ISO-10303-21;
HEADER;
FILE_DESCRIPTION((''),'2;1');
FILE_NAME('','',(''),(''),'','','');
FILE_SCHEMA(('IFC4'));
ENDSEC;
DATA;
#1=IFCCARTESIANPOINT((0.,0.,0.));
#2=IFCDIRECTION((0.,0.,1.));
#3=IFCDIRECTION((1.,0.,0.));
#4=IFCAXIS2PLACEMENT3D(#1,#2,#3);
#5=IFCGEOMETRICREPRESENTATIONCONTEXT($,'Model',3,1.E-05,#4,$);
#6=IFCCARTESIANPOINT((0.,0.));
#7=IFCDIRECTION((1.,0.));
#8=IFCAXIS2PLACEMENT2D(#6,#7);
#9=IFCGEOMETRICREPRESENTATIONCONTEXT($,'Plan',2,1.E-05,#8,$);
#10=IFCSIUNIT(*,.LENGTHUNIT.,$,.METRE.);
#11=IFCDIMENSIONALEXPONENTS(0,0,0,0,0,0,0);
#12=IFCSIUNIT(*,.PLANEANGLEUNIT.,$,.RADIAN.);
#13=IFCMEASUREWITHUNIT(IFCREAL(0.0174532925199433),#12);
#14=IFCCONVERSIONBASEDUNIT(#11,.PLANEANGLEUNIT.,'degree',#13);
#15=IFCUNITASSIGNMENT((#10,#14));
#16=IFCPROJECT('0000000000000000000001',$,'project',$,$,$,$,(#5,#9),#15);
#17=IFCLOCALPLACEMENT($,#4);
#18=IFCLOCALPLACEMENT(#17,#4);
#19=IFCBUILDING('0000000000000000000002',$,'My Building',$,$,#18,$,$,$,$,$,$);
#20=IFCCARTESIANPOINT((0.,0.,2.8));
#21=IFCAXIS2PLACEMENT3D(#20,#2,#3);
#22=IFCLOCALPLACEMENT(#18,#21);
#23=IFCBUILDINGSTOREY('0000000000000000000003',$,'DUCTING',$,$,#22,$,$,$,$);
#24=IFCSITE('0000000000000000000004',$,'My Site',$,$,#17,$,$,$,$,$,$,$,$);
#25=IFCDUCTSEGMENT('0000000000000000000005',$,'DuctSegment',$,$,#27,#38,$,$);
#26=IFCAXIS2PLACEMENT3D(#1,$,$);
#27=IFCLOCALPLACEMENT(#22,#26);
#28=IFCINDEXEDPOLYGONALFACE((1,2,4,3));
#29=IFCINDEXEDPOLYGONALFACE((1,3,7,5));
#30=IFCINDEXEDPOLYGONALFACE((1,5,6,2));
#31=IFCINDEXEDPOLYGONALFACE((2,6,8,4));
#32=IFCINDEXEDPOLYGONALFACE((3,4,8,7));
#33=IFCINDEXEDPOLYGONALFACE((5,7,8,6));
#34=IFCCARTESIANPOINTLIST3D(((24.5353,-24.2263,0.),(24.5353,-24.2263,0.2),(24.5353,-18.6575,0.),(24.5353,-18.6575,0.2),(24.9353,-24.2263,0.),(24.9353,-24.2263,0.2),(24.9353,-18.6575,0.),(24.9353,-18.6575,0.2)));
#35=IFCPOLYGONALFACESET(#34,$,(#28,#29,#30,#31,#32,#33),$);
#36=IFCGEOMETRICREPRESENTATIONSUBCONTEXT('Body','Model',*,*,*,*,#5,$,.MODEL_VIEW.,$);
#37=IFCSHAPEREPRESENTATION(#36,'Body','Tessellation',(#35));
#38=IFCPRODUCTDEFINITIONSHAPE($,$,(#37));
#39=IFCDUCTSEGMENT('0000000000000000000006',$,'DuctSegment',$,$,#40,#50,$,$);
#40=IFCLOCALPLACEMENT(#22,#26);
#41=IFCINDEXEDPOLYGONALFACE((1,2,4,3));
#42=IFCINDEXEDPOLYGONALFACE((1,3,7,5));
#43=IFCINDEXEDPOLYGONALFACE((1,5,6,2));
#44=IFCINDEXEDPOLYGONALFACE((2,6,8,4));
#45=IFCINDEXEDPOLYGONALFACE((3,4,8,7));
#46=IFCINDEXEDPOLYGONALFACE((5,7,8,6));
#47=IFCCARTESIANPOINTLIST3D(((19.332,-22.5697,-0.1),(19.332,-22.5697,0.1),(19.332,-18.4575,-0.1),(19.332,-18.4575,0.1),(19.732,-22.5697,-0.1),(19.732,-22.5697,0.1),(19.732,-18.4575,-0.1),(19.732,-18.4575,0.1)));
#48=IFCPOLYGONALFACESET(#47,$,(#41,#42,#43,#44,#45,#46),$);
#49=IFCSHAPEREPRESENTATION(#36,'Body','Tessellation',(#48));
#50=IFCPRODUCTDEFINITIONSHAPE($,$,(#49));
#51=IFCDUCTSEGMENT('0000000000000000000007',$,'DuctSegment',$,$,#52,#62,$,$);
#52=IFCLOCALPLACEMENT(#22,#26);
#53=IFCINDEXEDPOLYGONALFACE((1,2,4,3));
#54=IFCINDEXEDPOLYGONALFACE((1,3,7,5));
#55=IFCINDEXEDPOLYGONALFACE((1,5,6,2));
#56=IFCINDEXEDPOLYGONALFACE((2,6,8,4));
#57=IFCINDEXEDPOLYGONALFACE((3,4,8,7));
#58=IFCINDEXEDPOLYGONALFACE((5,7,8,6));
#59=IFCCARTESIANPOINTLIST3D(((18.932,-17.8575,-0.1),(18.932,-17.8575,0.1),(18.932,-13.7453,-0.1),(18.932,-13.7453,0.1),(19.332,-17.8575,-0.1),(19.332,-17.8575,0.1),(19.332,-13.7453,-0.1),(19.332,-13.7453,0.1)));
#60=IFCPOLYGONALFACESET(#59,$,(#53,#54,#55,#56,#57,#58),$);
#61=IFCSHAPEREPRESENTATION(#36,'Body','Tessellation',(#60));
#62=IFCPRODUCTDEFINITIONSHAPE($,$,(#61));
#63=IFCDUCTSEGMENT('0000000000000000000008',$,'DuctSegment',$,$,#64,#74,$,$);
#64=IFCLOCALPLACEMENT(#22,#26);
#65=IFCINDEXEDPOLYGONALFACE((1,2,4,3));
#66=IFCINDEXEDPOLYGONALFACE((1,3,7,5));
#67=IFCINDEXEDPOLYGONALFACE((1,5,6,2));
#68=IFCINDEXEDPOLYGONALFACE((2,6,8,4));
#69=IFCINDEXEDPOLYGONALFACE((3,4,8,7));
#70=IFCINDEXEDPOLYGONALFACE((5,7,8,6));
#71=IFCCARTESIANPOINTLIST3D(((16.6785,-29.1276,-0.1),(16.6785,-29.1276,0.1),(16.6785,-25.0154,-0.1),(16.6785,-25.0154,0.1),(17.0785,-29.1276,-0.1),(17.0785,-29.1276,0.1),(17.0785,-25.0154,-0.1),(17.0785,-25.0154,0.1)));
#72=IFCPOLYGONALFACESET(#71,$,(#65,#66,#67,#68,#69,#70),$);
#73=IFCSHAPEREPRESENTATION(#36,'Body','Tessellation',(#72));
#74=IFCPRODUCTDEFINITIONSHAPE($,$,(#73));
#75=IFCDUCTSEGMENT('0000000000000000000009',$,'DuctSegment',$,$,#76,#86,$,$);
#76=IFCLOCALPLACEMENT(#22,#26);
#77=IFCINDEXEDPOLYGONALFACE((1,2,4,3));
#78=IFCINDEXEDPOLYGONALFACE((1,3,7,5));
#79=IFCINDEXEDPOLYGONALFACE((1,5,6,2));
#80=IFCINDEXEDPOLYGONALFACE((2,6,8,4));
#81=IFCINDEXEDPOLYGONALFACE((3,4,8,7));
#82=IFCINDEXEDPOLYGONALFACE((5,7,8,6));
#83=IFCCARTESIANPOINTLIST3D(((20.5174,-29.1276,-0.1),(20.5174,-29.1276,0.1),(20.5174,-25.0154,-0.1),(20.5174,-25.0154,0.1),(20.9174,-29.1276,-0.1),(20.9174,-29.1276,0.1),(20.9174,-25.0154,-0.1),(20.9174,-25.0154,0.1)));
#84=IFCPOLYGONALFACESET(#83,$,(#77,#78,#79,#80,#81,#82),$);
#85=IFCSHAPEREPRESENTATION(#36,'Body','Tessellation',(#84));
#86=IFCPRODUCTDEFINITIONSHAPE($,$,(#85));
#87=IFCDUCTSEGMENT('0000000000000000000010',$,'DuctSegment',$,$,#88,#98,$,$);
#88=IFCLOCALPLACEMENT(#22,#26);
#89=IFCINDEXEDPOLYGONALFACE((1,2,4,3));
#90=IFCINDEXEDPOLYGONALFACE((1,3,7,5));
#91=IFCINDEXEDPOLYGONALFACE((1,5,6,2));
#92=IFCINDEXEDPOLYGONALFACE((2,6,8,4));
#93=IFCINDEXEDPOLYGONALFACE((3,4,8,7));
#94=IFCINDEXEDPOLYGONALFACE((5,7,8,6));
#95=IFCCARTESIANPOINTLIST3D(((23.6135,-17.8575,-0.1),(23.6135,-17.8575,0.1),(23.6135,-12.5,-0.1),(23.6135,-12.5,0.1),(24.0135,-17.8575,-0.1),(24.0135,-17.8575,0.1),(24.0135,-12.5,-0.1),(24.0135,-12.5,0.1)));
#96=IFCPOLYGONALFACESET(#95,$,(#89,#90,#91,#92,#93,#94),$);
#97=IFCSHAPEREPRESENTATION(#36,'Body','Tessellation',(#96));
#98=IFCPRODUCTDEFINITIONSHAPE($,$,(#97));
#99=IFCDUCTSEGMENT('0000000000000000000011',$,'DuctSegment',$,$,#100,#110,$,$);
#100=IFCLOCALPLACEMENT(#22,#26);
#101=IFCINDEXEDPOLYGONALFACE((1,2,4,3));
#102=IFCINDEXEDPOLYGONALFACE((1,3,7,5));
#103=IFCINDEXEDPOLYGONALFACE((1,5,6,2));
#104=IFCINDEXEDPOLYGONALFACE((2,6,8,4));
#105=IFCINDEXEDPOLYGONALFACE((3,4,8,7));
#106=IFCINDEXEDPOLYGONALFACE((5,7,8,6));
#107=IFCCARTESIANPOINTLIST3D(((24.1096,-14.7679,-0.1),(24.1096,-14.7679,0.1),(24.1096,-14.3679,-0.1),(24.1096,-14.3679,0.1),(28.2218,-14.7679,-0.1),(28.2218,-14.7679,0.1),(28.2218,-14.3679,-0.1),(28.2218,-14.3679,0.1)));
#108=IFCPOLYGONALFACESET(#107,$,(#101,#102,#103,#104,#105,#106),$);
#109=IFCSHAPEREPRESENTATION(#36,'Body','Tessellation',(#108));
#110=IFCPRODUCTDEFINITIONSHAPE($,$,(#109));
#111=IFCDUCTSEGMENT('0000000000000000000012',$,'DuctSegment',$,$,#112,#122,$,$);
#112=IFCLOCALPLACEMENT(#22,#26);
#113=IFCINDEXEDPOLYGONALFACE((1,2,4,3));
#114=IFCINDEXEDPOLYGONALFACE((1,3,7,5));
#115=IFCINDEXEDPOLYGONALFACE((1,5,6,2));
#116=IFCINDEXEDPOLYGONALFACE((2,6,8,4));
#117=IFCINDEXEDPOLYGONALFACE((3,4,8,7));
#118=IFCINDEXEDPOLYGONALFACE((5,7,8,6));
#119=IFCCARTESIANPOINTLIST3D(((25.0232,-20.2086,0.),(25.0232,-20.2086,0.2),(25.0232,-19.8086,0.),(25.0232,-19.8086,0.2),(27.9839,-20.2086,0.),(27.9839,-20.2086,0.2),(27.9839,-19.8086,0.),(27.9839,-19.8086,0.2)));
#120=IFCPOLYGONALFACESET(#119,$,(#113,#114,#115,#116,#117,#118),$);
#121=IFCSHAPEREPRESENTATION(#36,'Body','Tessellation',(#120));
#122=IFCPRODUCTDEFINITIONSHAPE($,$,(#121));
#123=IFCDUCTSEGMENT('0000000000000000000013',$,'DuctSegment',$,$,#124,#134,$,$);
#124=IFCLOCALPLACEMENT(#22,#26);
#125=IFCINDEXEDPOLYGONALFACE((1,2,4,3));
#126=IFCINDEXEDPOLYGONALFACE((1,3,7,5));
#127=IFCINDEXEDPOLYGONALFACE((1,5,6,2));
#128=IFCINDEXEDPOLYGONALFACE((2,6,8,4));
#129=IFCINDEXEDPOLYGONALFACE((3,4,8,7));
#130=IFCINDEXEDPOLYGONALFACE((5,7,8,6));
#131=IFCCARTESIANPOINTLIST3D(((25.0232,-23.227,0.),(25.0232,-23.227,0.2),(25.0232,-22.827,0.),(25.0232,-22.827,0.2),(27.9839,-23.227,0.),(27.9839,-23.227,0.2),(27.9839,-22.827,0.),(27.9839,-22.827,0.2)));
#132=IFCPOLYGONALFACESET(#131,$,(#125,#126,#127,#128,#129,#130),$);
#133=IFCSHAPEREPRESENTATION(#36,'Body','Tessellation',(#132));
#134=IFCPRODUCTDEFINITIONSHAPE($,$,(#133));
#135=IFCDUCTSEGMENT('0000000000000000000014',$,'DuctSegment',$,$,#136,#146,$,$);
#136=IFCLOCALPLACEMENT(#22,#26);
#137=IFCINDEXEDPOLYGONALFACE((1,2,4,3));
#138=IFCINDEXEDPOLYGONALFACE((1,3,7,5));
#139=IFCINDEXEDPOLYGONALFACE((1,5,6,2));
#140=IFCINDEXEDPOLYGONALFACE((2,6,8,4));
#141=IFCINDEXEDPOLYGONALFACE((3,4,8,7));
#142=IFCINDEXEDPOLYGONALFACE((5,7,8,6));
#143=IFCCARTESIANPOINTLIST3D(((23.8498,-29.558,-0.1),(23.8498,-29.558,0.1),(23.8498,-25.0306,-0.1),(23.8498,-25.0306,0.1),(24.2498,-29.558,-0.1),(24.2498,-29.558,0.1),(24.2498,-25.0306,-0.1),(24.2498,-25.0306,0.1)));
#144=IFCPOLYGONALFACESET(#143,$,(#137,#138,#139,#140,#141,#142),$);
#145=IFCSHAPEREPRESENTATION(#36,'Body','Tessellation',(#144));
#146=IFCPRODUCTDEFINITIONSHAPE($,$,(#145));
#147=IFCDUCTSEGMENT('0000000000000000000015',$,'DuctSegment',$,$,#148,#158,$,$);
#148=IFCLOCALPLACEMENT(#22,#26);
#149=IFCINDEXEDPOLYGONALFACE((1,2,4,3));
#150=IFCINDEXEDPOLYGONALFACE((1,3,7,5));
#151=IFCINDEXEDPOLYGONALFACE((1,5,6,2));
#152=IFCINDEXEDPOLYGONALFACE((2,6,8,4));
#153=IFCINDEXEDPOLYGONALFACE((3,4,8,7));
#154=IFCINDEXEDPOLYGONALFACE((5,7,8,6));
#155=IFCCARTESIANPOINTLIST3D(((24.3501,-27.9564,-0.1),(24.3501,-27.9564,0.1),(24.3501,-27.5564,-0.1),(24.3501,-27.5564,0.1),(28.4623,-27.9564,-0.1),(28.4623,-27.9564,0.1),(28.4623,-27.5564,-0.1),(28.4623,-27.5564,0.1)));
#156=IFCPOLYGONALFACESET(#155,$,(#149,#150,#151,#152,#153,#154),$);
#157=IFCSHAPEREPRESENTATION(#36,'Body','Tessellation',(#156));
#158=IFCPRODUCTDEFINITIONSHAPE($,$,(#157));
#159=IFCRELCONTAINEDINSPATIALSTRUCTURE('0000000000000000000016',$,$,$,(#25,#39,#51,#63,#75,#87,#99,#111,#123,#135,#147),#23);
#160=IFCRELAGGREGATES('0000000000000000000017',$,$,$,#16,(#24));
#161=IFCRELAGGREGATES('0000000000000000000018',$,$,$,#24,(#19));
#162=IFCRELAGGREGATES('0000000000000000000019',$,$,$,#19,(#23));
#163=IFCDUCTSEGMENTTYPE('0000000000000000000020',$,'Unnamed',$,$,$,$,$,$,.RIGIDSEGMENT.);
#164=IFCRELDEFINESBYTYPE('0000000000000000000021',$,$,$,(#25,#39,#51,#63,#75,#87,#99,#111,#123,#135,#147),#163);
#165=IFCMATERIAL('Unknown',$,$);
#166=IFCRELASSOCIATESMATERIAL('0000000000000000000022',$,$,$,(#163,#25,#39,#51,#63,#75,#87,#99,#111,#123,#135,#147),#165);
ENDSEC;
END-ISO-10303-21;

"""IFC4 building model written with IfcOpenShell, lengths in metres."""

from ifc_helpers import new_model, entity, si_unit, converted_unit, frame, origin_with_axes, origin_2d_with_axis, place, context, subcontext, project, spatial, rectangle, extrude, material, material_profile, profile_set, profile_usage, type_object, element, save


model = new_model("IFC4")

# Units and contexts
model_context = context("Model", 3, precision=1e-05, world=origin_with_axes())
plan_context = context("Plan", 2, precision=1e-05, world=origin_2d_with_axis())
body_context = subcontext(model_context, "Body", "Model", "MODEL_VIEW")
ifc_project = project(units=[si_unit("LENGTHUNIT", "METRE"), converted_unit("PLANEANGLEUNIT", "degree", entity("IfcReal", 0.0174532925199433), si_unit("PLANEANGLEUNIT", "RADIAN"), dimensions=[0, 0, 0, 0, 0, 0, 0])], contexts=[model_context, plan_context])

# Site, building, storey
site_placement = place(None, origin_with_axes())
site = spatial("IfcSite", under=ifc_project, at=site_placement, Name="My Site")
building_placement = place(site_placement, origin_with_axes())
building = spatial("IfcBuilding", under=site, at=building_placement, Name="My Building")
storey_placement = place(building_placement, frame((0.0, 0.0, 2.8), z_axis=(0.0, 0.0, 1.0), x_axis=(1.0, 0.0, 0.0)))
storey = spatial("IfcBuildingStorey", under=building, at=storey_placement, Name="DUCTING")

# Duct segments
ifc_material = material(Name="Unknown")
ifc_material_profile_1 = material_profile(ifc_material, rectangle(XDim=0.4, YDim=0.2))
ifc_profile_set_1 = profile_set([ifc_material_profile_1])
ifc_profile_usage_1 = profile_usage(ifc_profile_set_1, cardinal=5)
duct_segment_type = type_object("IfcDuctSegmentType", Name="Unnamed", PredefinedType="RIGIDSEGMENT", material=ifc_profile_set_1)
duct_segment_1_placement = place(storey_placement, frame((24.7353, -18.6575, 0.1), z_axis=(0.0, -1.0, 0.0), x_axis=(1.0, 0.0, 0.0)))
element("IfcDuctSegment", 1, at=duct_segment_1_placement, inside=storey, type_object=duct_segment_type, material=ifc_profile_usage_1, Name="DuctSegment", context=body_context, shape_type="SweptSolid", body=[
    extrude(rectangle(XDim=0.4, YDim=0.2), origin_with_axes(), (0.0, 0.0, 1.0), 5.5688),
])
ifc_profile_usage_2 = profile_usage(ifc_profile_set_1, cardinal=5)
duct_segment_2_placement = place(storey_placement, frame((19.532, -18.4575, 0.0), z_axis=(0.0, -1.0, 0.0), x_axis=(1.0, 0.0, 0.0)))
element("IfcDuctSegment", 2, at=duct_segment_2_placement, inside=storey, type_object=duct_segment_type, material=ifc_profile_usage_2, Name="DuctSegment", context=body_context, shape_type="SweptSolid", body=[
    extrude(rectangle(XDim=0.4, YDim=0.2), origin_with_axes(), (0.0, 0.0, 1.0), 4.1122),
])
ifc_profile_usage_3 = profile_usage(ifc_profile_set_1, cardinal=5)
duct_segment_3_placement = place(storey_placement, frame((19.132, -17.8575, 0.0), z_axis=(0.0, 1.0, 0.0), x_axis=(-1.0, 0.0, 0.0)))
element("IfcDuctSegment", 3, at=duct_segment_3_placement, inside=storey, type_object=duct_segment_type, material=ifc_profile_usage_3, Name="DuctSegment", context=body_context, shape_type="SweptSolid", body=[
    extrude(rectangle(XDim=0.4, YDim=0.2), origin_with_axes(), (0.0, 0.0, 1.0), 4.1122),
])
ifc_profile_usage_4 = profile_usage(ifc_profile_set_1, cardinal=5)
duct_segment_4_placement = place(storey_placement, frame((16.8785, -25.0154, 0.0), z_axis=(0.0, -1.0, 0.0), x_axis=(1.0, 0.0, 0.0)))
element("IfcDuctSegment", 4, at=duct_segment_4_placement, inside=storey, type_object=duct_segment_type, material=ifc_profile_usage_4, Name="DuctSegment", context=body_context, shape_type="SweptSolid", body=[
    extrude(rectangle(XDim=0.4, YDim=0.2), origin_with_axes(), (0.0, 0.0, 1.0), 4.1122),
])
ifc_profile_usage_5 = profile_usage(ifc_profile_set_1, cardinal=5)
duct_segment_5_placement = place(storey_placement, frame((20.7174, -25.0154, 0.0), z_axis=(0.0, -1.0, 0.0), x_axis=(1.0, 0.0, 0.0)))
element("IfcDuctSegment", 5, at=duct_segment_5_placement, inside=storey, type_object=duct_segment_type, material=ifc_profile_usage_5, Name="DuctSegment", context=body_context, shape_type="SweptSolid", body=[
    extrude(rectangle(XDim=0.4, YDim=0.2), origin_with_axes(), (0.0, 0.0, 1.0), 4.1122),
])
ifc_profile_usage_6 = profile_usage(ifc_profile_set_1, cardinal=5)
duct_segment_6_placement = place(storey_placement, frame((23.8135, -17.8575, 0.0), z_axis=(0.0, 1.0, 0.0), x_axis=(-1.0, 0.0, 0.0)))
element("IfcDuctSegment", 6, at=duct_segment_6_placement, inside=storey, type_object=duct_segment_type, material=ifc_profile_usage_6, Name="DuctSegment", context=body_context, shape_type="SweptSolid", body=[
    extrude(rectangle(XDim=0.4, YDim=0.2), origin_with_axes(), (0.0, 0.0, 1.0), 5.3575),
])
ifc_profile_usage_7 = profile_usage(ifc_profile_set_1, cardinal=5)
duct_segment_7_placement = place(storey_placement, frame((24.1096, -14.5679, 0.0), z_axis=(1.0, 0.0, 0.0), x_axis=(0.0, 1.0, 0.0)))
element("IfcDuctSegment", 7, at=duct_segment_7_placement, inside=storey, type_object=duct_segment_type, material=ifc_profile_usage_7, Name="DuctSegment", context=body_context, shape_type="SweptSolid", body=[
    extrude(rectangle(XDim=0.4, YDim=0.2), origin_with_axes(), (0.0, 0.0, 1.0), 4.1122),
])
ifc_profile_usage_8 = profile_usage(ifc_profile_set_1, cardinal=5)
duct_segment_8_placement = place(storey_placement, frame((25.0232, -20.0086, 0.1), z_axis=(1.0, 0.0, 0.0), x_axis=(0.0, 1.0, 0.0)))
element("IfcDuctSegment", 8, at=duct_segment_8_placement, inside=storey, type_object=duct_segment_type, material=ifc_profile_usage_8, Name="DuctSegment", context=body_context, shape_type="SweptSolid", body=[
    extrude(rectangle(XDim=0.4, YDim=0.2), origin_with_axes(), (0.0, 0.0, 1.0), 2.9607),
])
ifc_profile_usage_9 = profile_usage(ifc_profile_set_1, cardinal=5)
duct_segment_9_placement = place(storey_placement, frame((25.0232, -23.027, 0.1), z_axis=(1.0, 0.0, 0.0), x_axis=(0.0, 1.0, 0.0)))
element("IfcDuctSegment", 9, at=duct_segment_9_placement, inside=storey, type_object=duct_segment_type, material=ifc_profile_usage_9, Name="DuctSegment", context=body_context, shape_type="SweptSolid", body=[
    extrude(rectangle(XDim=0.4, YDim=0.2), origin_with_axes(), (0.0, 0.0, 1.0), 2.9607),
])
ifc_profile_usage_10 = profile_usage(ifc_profile_set_1, cardinal=5)
duct_segment_10_placement = place(storey_placement, frame((24.0498, -25.0306, 0.0), z_axis=(0.0, -1.0, 0.0), x_axis=(1.0, 0.0, 0.0)))
element("IfcDuctSegment", 10, at=duct_segment_10_placement, inside=storey, type_object=duct_segment_type, material=ifc_profile_usage_10, Name="DuctSegment", context=body_context, shape_type="SweptSolid", body=[
    extrude(rectangle(XDim=0.4, YDim=0.2), origin_with_axes(), (0.0, 0.0, 1.0), 4.5275),
])
ifc_profile_usage_11 = profile_usage(ifc_profile_set_1, cardinal=5)
duct_segment_11_placement = place(storey_placement, frame((24.3501, -27.7564, 0.0), z_axis=(1.0, 0.0, 0.0), x_axis=(0.0, 1.0, 0.0)))
element("IfcDuctSegment", 11, at=duct_segment_11_placement, inside=storey, type_object=duct_segment_type, material=ifc_profile_usage_11, Name="DuctSegment", context=body_context, shape_type="SweptSolid", body=[
    extrude(rectangle(XDim=0.4, YDim=0.2), origin_with_axes(), (0.0, 0.0, 1.0), 4.1122),
])

save(model, "model.ifc")
